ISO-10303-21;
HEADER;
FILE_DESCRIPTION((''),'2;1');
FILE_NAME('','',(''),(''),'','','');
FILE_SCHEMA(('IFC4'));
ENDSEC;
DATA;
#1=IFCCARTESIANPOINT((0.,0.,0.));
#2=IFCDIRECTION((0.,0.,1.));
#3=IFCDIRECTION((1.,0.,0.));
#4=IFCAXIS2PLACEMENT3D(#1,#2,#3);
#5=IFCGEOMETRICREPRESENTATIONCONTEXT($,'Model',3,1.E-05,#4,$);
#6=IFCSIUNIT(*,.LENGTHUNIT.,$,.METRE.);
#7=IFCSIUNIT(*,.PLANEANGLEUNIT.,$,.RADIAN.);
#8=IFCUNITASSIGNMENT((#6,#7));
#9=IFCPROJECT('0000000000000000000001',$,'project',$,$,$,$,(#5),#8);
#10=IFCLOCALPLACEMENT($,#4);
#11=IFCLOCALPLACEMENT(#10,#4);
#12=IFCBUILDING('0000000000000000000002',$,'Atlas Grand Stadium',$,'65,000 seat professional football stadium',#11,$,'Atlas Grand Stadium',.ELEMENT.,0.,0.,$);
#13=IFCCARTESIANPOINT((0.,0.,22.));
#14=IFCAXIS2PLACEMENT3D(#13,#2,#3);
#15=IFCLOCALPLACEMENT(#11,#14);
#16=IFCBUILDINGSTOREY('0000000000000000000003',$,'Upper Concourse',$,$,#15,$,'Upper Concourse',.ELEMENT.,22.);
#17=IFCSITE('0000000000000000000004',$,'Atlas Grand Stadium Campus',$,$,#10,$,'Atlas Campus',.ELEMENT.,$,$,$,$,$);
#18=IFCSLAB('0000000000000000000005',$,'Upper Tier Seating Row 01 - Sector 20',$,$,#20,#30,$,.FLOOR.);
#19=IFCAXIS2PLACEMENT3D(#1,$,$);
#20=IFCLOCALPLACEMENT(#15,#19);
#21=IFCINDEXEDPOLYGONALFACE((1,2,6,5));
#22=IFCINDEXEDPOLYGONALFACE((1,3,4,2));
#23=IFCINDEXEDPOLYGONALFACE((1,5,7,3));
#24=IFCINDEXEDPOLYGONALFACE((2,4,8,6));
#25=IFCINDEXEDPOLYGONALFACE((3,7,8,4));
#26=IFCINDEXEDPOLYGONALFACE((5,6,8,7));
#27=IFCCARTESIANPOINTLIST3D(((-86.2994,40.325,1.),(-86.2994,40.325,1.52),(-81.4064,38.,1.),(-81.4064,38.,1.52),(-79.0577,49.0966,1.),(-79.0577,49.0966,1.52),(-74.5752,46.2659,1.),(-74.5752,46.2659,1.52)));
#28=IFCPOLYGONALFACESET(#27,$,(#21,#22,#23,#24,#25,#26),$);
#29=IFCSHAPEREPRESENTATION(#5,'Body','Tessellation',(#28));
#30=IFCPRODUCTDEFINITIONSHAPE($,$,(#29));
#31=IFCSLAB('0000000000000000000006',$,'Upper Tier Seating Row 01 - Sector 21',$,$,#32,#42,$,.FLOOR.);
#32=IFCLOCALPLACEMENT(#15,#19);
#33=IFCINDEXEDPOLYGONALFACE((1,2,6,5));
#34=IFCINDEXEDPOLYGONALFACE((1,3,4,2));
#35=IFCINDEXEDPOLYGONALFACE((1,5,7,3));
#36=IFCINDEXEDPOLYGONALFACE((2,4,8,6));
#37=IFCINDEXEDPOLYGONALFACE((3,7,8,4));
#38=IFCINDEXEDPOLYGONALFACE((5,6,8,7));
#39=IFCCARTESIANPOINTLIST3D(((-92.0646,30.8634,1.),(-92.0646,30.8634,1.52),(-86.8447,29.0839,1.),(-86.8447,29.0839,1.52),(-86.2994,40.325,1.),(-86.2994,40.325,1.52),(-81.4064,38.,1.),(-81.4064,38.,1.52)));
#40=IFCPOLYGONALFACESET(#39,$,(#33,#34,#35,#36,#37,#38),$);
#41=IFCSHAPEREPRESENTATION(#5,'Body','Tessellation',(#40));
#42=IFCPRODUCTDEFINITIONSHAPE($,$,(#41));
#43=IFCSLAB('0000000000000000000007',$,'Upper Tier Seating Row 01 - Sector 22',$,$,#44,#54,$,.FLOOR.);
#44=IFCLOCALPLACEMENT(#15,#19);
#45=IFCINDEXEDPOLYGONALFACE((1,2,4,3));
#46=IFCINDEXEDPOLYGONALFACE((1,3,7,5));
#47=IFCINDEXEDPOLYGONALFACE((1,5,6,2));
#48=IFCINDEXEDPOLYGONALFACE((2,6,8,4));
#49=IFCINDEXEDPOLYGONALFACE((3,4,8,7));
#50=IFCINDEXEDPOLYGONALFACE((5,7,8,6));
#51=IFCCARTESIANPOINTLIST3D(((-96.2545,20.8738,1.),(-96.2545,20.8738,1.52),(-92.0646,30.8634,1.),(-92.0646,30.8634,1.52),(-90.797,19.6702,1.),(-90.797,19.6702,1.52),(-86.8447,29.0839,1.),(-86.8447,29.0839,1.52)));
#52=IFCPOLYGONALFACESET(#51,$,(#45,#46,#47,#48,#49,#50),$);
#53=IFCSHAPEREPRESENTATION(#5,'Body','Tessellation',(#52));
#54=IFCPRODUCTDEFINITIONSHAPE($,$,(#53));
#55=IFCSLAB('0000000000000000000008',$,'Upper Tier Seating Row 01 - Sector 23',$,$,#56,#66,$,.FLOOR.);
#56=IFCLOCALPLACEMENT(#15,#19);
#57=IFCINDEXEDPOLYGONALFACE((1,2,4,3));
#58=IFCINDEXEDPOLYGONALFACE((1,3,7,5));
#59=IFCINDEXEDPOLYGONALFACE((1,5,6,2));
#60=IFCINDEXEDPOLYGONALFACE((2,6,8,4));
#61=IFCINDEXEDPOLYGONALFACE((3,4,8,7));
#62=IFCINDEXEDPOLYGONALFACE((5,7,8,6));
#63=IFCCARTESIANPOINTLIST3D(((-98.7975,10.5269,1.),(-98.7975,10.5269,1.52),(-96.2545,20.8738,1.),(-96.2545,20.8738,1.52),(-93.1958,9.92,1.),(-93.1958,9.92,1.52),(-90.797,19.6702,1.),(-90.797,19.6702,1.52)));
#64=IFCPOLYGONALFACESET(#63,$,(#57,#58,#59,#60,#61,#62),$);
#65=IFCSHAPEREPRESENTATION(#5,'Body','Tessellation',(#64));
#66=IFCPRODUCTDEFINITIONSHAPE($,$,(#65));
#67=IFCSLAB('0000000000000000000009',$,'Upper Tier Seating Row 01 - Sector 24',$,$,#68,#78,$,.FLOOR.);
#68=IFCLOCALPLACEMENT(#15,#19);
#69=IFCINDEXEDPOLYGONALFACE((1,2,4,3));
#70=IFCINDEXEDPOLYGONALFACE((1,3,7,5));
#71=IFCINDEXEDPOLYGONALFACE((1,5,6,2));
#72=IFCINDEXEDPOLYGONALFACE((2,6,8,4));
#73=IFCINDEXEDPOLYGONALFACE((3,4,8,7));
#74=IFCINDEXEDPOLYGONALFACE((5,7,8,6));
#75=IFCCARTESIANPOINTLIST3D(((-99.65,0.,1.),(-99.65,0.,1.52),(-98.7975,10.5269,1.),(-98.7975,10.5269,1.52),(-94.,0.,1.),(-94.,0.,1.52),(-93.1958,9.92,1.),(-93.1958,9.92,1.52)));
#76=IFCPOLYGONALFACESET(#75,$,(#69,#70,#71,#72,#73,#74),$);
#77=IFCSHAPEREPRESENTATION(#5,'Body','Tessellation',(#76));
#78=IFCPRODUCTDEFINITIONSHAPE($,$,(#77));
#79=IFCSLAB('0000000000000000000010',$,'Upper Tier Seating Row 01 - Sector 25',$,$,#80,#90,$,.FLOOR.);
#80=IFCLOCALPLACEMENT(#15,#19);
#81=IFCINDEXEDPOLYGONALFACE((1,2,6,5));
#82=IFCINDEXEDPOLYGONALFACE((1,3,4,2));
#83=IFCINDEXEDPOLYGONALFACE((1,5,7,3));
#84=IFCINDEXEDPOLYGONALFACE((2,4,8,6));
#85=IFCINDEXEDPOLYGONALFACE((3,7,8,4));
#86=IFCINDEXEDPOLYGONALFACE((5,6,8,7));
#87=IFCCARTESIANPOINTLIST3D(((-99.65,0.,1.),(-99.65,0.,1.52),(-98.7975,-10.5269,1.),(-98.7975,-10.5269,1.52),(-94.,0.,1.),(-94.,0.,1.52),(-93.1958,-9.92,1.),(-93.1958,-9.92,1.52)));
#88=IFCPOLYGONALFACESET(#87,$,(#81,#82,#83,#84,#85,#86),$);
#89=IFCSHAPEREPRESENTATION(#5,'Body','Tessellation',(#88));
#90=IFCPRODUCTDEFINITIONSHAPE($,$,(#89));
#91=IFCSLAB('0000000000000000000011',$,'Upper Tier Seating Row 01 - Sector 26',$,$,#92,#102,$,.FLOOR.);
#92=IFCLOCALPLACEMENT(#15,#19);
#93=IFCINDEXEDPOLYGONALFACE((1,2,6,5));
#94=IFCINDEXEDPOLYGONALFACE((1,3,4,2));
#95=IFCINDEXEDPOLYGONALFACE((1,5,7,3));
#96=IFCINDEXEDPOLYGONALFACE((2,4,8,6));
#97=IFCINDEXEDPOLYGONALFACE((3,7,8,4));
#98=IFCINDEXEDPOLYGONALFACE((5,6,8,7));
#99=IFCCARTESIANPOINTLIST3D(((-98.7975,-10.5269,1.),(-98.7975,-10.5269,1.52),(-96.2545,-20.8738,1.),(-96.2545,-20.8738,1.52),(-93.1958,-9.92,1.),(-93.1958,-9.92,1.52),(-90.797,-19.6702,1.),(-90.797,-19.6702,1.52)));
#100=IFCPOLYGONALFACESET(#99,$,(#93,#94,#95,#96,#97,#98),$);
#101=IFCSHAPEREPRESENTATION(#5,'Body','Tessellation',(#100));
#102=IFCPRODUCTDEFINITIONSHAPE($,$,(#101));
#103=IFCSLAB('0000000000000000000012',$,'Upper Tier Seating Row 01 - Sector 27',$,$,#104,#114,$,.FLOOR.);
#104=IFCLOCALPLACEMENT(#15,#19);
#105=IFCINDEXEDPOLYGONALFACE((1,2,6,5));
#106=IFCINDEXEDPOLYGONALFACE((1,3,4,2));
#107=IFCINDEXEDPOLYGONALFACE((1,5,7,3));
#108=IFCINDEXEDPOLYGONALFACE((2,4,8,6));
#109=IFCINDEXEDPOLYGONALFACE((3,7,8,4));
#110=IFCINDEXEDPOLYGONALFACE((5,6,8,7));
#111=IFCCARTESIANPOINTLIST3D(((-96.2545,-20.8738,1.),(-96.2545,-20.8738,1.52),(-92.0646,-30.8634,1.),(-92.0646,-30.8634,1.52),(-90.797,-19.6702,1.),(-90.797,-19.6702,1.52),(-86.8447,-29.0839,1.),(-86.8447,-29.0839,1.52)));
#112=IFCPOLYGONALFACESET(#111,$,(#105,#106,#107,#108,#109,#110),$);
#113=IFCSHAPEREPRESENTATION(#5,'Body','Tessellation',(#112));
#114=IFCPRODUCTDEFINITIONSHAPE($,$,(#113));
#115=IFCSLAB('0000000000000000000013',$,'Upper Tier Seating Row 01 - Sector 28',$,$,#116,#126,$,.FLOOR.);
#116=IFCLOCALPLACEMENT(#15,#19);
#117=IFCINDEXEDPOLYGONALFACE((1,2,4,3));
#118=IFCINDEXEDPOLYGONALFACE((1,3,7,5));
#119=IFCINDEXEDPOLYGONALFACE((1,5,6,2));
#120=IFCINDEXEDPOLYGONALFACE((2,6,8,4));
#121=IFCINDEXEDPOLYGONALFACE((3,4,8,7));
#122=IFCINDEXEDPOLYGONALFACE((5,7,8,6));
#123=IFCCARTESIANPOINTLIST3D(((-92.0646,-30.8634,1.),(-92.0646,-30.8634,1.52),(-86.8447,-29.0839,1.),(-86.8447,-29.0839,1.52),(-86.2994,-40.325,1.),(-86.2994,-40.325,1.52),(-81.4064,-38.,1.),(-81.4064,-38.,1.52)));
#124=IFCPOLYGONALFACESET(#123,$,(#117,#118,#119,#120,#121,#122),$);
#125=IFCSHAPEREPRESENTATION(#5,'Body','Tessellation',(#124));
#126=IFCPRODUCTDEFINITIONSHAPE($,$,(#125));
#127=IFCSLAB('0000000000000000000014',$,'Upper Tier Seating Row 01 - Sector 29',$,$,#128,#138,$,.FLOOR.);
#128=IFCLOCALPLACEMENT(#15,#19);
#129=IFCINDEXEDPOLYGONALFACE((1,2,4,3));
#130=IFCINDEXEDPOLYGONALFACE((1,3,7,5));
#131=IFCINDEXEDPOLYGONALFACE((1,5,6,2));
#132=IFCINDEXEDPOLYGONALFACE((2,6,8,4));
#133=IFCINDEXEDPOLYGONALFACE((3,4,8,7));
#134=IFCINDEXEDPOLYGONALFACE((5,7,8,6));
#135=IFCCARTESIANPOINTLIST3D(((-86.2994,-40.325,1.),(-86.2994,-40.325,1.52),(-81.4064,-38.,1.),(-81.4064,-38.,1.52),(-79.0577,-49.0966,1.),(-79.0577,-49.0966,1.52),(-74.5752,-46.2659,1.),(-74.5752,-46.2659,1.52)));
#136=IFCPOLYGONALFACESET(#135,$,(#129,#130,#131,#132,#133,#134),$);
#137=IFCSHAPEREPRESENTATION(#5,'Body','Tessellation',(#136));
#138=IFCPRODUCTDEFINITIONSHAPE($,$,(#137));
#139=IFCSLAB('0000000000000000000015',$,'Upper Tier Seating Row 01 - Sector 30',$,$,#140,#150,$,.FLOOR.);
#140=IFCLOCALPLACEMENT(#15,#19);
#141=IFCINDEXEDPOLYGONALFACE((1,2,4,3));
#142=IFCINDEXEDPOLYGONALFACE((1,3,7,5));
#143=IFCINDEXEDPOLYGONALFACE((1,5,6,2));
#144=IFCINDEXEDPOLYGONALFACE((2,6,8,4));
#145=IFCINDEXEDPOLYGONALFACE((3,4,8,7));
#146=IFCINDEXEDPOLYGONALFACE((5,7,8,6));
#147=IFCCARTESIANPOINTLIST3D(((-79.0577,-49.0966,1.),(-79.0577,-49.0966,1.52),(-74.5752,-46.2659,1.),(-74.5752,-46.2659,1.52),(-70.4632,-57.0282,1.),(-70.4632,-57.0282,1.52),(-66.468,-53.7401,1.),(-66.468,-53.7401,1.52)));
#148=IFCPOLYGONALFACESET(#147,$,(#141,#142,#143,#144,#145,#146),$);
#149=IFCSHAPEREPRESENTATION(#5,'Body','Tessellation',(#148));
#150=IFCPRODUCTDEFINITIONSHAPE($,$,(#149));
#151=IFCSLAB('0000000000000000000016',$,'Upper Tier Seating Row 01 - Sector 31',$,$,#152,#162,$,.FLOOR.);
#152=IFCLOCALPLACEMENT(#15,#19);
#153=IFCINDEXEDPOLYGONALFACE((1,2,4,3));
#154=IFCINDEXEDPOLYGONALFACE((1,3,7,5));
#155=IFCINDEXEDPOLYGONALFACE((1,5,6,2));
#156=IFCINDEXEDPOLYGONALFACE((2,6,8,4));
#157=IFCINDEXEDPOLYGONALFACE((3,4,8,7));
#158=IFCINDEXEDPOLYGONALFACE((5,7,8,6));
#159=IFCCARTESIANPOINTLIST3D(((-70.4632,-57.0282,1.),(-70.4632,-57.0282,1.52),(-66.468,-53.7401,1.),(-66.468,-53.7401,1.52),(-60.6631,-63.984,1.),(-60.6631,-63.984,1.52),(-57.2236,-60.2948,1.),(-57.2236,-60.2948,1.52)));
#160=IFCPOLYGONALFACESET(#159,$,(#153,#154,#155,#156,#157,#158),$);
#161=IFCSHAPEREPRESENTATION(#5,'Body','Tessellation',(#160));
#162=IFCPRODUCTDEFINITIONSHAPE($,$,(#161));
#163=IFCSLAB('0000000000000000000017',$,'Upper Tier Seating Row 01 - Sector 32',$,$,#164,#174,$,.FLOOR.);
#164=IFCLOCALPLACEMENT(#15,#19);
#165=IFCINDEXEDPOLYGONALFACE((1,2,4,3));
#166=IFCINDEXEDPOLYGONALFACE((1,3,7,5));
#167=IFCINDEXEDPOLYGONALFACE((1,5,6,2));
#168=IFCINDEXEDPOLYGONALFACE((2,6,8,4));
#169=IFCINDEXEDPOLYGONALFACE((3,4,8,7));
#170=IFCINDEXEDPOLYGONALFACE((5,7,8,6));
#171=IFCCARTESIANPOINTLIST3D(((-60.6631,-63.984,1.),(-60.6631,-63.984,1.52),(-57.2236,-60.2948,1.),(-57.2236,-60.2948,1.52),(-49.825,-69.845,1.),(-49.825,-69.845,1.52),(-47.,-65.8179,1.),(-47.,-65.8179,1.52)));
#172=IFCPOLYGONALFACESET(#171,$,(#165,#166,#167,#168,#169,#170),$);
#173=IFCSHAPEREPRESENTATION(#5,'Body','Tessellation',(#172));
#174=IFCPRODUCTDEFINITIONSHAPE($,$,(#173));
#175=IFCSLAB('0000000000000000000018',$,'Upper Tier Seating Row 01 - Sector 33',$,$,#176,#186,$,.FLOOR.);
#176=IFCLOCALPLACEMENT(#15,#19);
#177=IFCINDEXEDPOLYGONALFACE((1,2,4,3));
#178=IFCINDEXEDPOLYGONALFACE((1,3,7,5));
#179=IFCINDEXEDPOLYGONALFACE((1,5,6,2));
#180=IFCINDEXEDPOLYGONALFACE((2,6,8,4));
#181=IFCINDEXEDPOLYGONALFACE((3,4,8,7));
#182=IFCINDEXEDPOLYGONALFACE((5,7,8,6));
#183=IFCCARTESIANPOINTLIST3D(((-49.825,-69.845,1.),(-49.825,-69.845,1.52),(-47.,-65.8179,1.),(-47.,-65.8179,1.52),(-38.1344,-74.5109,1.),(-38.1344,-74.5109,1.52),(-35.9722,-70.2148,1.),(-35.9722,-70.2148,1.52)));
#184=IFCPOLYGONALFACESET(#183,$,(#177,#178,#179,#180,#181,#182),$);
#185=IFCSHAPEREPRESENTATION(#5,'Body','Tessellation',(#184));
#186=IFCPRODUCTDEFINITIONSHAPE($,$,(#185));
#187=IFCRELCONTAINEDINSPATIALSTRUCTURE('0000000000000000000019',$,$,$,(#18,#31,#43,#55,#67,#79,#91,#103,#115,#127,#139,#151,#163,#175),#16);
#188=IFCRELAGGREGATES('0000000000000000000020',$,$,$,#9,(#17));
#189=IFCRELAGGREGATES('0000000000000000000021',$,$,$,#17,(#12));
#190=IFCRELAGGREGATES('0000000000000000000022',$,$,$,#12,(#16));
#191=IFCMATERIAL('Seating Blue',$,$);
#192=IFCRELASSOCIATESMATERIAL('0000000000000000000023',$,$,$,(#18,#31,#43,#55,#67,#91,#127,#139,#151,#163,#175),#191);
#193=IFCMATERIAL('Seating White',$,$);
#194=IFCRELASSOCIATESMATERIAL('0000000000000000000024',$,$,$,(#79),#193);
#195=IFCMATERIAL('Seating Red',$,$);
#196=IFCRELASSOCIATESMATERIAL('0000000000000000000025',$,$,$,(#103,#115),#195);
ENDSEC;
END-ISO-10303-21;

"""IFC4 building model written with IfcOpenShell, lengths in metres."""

from ifc_helpers import new_model, si_unit, frame, origin_with_axes, place, context, project, spatial, polyline, outline, extrude, material, element, save


model = new_model("IFC4")

# Units and contexts
model_context = context("Model", 3, precision=1e-05, world=origin_with_axes())
ifc_project = project(units=[si_unit("LENGTHUNIT", "METRE"), si_unit("PLANEANGLEUNIT", "RADIAN")], contexts=[model_context])

# Site, building, storey
site_placement = place(None, origin_with_axes())
site = spatial("IfcSite", under=ifc_project, at=site_placement, Name="Atlas Grand Stadium Campus", LongName="Atlas Campus", CompositionType="ELEMENT")
building_placement = place(site_placement, origin_with_axes())
building = spatial("IfcBuilding", under=site, at=building_placement, Name="Atlas Grand Stadium", ObjectType="65,000 seat professional football stadium", LongName="Atlas Grand Stadium", CompositionType="ELEMENT", ElevationOfRefHeight=0.0, ElevationOfTerrain=0.0)
storey_placement = place(building_placement, frame((0.0, 0.0, 22.0), z_axis=(0.0, 0.0, 1.0), x_axis=(1.0, 0.0, 0.0)))
storey = spatial("IfcBuildingStorey", under=building, at=storey_placement, Name="Upper Concourse", LongName="Upper Concourse", CompositionType="ELEMENT", Elevation=22.0)

# Slabs
ifc_material_1 = material(Name="Seating Blue")
slab_1_placement = place(storey_placement, frame((0.0, 0.0, 1.0), z_axis=(0.0, 0.0, 1.0), x_axis=(1.0, 0.0, 0.0)))
element("IfcSlab", 1, at=slab_1_placement, inside=storey, material=ifc_material_1, Name="Upper Tier Seating Row 01 - Sector 20", PredefinedType="FLOOR", context=model_context, shape_type="SweptSolid", body=[
    extrude(outline(polyline([(-79.0577, 49.0966), (-86.2994, 40.325), (-81.4064, 38.0), (-74.5752, 46.2659), (-79.0577, 49.0966)])), origin_with_axes(), (0.0, 0.0, 1.0), 0.52),
])
slab_2_placement = place(storey_placement, frame((0.0, 0.0, 1.0), z_axis=(0.0, 0.0, 1.0), x_axis=(1.0, 0.0, 0.0)))
element("IfcSlab", 2, at=slab_2_placement, inside=storey, material=ifc_material_1, Name="Upper Tier Seating Row 01 - Sector 21", PredefinedType="FLOOR", context=model_context, shape_type="SweptSolid", body=[
    extrude(outline(polyline([(-86.2994, 40.325), (-92.0646, 30.8634), (-86.8447, 29.0839), (-81.4064, 38.0), (-86.2994, 40.325)])), origin_with_axes(), (0.0, 0.0, 1.0), 0.52),
])
slab_3_placement = place(storey_placement, frame((0.0, 0.0, 1.0), z_axis=(0.0, 0.0, 1.0), x_axis=(1.0, 0.0, 0.0)))
element("IfcSlab", 3, at=slab_3_placement, inside=storey, material=ifc_material_1, Name="Upper Tier Seating Row 01 - Sector 22", PredefinedType="FLOOR", context=model_context, shape_type="SweptSolid", body=[
    extrude(outline(polyline([(-92.0646, 30.8634), (-96.2545, 20.8738), (-90.797, 19.6702), (-86.8447, 29.0839), (-92.0646, 30.8634)])), origin_with_axes(), (0.0, 0.0, 1.0), 0.52),
])
slab_4_placement = place(storey_placement, frame((0.0, 0.0, 1.0), z_axis=(0.0, 0.0, 1.0), x_axis=(1.0, 0.0, 0.0)))
element("IfcSlab", 4, at=slab_4_placement, inside=storey, material=ifc_material_1, Name="Upper Tier Seating Row 01 - Sector 23", PredefinedType="FLOOR", context=model_context, shape_type="SweptSolid", body=[
    extrude(outline(polyline([(-96.2545, 20.8738), (-98.7975, 10.5269), (-93.1958, 9.92), (-90.797, 19.6702), (-96.2545, 20.8738)])), origin_with_axes(), (0.0, 0.0, 1.0), 0.52),
])
slab_5_placement = place(storey_placement, frame((0.0, 0.0, 1.0), z_axis=(0.0, 0.0, 1.0), x_axis=(1.0, 0.0, 0.0)))
element("IfcSlab", 5, at=slab_5_placement, inside=storey, material=ifc_material_1, Name="Upper Tier Seating Row 01 - Sector 24", PredefinedType="FLOOR", context=model_context, shape_type="SweptSolid", body=[
    extrude(outline(polyline([(-98.7975, 10.5269), (-99.65, 0.0), (-94.0, 0.0), (-93.1958, 9.92), (-98.7975, 10.5269)])), origin_with_axes(), (0.0, 0.0, 1.0), 0.52),
])
ifc_material_2 = material(Name="Seating White")
slab_6_placement = place(storey_placement, frame((0.0, 0.0, 1.0), z_axis=(0.0, 0.0, 1.0), x_axis=(1.0, 0.0, 0.0)))
element("IfcSlab", 6, at=slab_6_placement, inside=storey, material=ifc_material_2, Name="Upper Tier Seating Row 01 - Sector 25", PredefinedType="FLOOR", context=model_context, shape_type="SweptSolid", body=[
    extrude(outline(polyline([(-99.65, 0.0), (-98.7975, -10.5269), (-93.1958, -9.92), (-94.0, 0.0), (-99.65, 0.0)])), origin_with_axes(), (0.0, 0.0, 1.0), 0.52),
])
slab_7_placement = place(storey_placement, frame((0.0, 0.0, 1.0), z_axis=(0.0, 0.0, 1.0), x_axis=(1.0, 0.0, 0.0)))
element("IfcSlab", 7, at=slab_7_placement, inside=storey, material=ifc_material_1, Name="Upper Tier Seating Row 01 - Sector 26", PredefinedType="FLOOR", context=model_context, shape_type="SweptSolid", body=[
    extrude(outline(polyline([(-98.7975, -10.5269), (-96.2545, -20.8738), (-90.797, -19.6702), (-93.1958, -9.92), (-98.7975, -10.5269)])), origin_with_axes(), (0.0, 0.0, 1.0), 0.52),
])
ifc_material_3 = material(Name="Seating Red")
slab_8_placement = place(storey_placement, frame((0.0, 0.0, 1.0), z_axis=(0.0, 0.0, 1.0), x_axis=(1.0, 0.0, 0.0)))
element("IfcSlab", 8, at=slab_8_placement, inside=storey, material=ifc_material_3, Name="Upper Tier Seating Row 01 - Sector 27", PredefinedType="FLOOR", context=model_context, shape_type="SweptSolid", body=[
    extrude(outline(polyline([(-96.2545, -20.8738), (-92.0646, -30.8634), (-86.8447, -29.0839), (-90.797, -19.6702), (-96.2545, -20.8738)])), origin_with_axes(), (0.0, 0.0, 1.0), 0.52),
])
slab_9_placement = place(storey_placement, frame((0.0, 0.0, 1.0), z_axis=(0.0, 0.0, 1.0), x_axis=(1.0, 0.0, 0.0)))
element("IfcSlab", 9, at=slab_9_placement, inside=storey, material=ifc_material_3, Name="Upper Tier Seating Row 01 - Sector 28", PredefinedType="FLOOR", context=model_context, shape_type="SweptSolid", body=[
    extrude(outline(polyline([(-92.0646, -30.8634), (-86.2994, -40.325), (-81.4064, -38.0), (-86.8447, -29.0839), (-92.0646, -30.8634)])), origin_with_axes(), (0.0, 0.0, 1.0), 0.52),
])
slab_10_placement = place(storey_placement, frame((0.0, 0.0, 1.0), z_axis=(0.0, 0.0, 1.0), x_axis=(1.0, 0.0, 0.0)))
element("IfcSlab", 10, at=slab_10_placement, inside=storey, material=ifc_material_1, Name="Upper Tier Seating Row 01 - Sector 29", PredefinedType="FLOOR", context=model_context, shape_type="SweptSolid", body=[
    extrude(outline(polyline([(-86.2994, -40.325), (-79.0577, -49.0966), (-74.5752, -46.2659), (-81.4064, -38.0), (-86.2994, -40.325)])), origin_with_axes(), (0.0, 0.0, 1.0), 0.52),
])
slab_11_placement = place(storey_placement, frame((0.0, 0.0, 1.0), z_axis=(0.0, 0.0, 1.0), x_axis=(1.0, 0.0, 0.0)))
element("IfcSlab", 11, at=slab_11_placement, inside=storey, material=ifc_material_1, Name="Upper Tier Seating Row 01 - Sector 30", PredefinedType="FLOOR", context=model_context, shape_type="SweptSolid", body=[
    extrude(outline(polyline([(-79.0577, -49.0966), (-70.4632, -57.0282), (-66.468, -53.7401), (-74.5752, -46.2659), (-79.0577, -49.0966)])), origin_with_axes(), (0.0, 0.0, 1.0), 0.52),
])
slab_12_placement = place(storey_placement, frame((0.0, 0.0, 1.0), z_axis=(0.0, 0.0, 1.0), x_axis=(1.0, 0.0, 0.0)))
element("IfcSlab", 12, at=slab_12_placement, inside=storey, material=ifc_material_1, Name="Upper Tier Seating Row 01 - Sector 31", PredefinedType="FLOOR", context=model_context, shape_type="SweptSolid", body=[
    extrude(outline(polyline([(-70.4632, -57.0282), (-60.6631, -63.984), (-57.2236, -60.2948), (-66.468, -53.7401), (-70.4632, -57.0282)])), origin_with_axes(), (0.0, 0.0, 1.0), 0.52),
])
slab_13_placement = place(storey_placement, frame((0.0, 0.0, 1.0), z_axis=(0.0, 0.0, 1.0), x_axis=(1.0, 0.0, 0.0)))
element("IfcSlab", 13, at=slab_13_placement, inside=storey, material=ifc_material_1, Name="Upper Tier Seating Row 01 - Sector 32", PredefinedType="FLOOR", context=model_context, shape_type="SweptSolid", body=[
    extrude(outline(polyline([(-60.6631, -63.984), (-49.825, -69.8449), (-47.0, -65.8179), (-57.2236, -60.2948), (-60.6631, -63.984)])), origin_with_axes(), (0.0, 0.0, 1.0), 0.52),
])
slab_14_placement = place(storey_placement, frame((0.0, 0.0, 1.0), z_axis=(0.0, 0.0, 1.0), x_axis=(1.0, 0.0, 0.0)))
element("IfcSlab", 14, at=slab_14_placement, inside=storey, material=ifc_material_1, Name="Upper Tier Seating Row 01 - Sector 33", PredefinedType="FLOOR", context=model_context, shape_type="SweptSolid", body=[
    extrude(outline(polyline([(-49.825, -69.8449), (-38.1344, -74.5109), (-35.9722, -70.2148), (-47.0, -65.8179), (-49.825, -69.8449)])), origin_with_axes(), (0.0, 0.0, 1.0), 0.52),
])

save(model, "model.ifc")
